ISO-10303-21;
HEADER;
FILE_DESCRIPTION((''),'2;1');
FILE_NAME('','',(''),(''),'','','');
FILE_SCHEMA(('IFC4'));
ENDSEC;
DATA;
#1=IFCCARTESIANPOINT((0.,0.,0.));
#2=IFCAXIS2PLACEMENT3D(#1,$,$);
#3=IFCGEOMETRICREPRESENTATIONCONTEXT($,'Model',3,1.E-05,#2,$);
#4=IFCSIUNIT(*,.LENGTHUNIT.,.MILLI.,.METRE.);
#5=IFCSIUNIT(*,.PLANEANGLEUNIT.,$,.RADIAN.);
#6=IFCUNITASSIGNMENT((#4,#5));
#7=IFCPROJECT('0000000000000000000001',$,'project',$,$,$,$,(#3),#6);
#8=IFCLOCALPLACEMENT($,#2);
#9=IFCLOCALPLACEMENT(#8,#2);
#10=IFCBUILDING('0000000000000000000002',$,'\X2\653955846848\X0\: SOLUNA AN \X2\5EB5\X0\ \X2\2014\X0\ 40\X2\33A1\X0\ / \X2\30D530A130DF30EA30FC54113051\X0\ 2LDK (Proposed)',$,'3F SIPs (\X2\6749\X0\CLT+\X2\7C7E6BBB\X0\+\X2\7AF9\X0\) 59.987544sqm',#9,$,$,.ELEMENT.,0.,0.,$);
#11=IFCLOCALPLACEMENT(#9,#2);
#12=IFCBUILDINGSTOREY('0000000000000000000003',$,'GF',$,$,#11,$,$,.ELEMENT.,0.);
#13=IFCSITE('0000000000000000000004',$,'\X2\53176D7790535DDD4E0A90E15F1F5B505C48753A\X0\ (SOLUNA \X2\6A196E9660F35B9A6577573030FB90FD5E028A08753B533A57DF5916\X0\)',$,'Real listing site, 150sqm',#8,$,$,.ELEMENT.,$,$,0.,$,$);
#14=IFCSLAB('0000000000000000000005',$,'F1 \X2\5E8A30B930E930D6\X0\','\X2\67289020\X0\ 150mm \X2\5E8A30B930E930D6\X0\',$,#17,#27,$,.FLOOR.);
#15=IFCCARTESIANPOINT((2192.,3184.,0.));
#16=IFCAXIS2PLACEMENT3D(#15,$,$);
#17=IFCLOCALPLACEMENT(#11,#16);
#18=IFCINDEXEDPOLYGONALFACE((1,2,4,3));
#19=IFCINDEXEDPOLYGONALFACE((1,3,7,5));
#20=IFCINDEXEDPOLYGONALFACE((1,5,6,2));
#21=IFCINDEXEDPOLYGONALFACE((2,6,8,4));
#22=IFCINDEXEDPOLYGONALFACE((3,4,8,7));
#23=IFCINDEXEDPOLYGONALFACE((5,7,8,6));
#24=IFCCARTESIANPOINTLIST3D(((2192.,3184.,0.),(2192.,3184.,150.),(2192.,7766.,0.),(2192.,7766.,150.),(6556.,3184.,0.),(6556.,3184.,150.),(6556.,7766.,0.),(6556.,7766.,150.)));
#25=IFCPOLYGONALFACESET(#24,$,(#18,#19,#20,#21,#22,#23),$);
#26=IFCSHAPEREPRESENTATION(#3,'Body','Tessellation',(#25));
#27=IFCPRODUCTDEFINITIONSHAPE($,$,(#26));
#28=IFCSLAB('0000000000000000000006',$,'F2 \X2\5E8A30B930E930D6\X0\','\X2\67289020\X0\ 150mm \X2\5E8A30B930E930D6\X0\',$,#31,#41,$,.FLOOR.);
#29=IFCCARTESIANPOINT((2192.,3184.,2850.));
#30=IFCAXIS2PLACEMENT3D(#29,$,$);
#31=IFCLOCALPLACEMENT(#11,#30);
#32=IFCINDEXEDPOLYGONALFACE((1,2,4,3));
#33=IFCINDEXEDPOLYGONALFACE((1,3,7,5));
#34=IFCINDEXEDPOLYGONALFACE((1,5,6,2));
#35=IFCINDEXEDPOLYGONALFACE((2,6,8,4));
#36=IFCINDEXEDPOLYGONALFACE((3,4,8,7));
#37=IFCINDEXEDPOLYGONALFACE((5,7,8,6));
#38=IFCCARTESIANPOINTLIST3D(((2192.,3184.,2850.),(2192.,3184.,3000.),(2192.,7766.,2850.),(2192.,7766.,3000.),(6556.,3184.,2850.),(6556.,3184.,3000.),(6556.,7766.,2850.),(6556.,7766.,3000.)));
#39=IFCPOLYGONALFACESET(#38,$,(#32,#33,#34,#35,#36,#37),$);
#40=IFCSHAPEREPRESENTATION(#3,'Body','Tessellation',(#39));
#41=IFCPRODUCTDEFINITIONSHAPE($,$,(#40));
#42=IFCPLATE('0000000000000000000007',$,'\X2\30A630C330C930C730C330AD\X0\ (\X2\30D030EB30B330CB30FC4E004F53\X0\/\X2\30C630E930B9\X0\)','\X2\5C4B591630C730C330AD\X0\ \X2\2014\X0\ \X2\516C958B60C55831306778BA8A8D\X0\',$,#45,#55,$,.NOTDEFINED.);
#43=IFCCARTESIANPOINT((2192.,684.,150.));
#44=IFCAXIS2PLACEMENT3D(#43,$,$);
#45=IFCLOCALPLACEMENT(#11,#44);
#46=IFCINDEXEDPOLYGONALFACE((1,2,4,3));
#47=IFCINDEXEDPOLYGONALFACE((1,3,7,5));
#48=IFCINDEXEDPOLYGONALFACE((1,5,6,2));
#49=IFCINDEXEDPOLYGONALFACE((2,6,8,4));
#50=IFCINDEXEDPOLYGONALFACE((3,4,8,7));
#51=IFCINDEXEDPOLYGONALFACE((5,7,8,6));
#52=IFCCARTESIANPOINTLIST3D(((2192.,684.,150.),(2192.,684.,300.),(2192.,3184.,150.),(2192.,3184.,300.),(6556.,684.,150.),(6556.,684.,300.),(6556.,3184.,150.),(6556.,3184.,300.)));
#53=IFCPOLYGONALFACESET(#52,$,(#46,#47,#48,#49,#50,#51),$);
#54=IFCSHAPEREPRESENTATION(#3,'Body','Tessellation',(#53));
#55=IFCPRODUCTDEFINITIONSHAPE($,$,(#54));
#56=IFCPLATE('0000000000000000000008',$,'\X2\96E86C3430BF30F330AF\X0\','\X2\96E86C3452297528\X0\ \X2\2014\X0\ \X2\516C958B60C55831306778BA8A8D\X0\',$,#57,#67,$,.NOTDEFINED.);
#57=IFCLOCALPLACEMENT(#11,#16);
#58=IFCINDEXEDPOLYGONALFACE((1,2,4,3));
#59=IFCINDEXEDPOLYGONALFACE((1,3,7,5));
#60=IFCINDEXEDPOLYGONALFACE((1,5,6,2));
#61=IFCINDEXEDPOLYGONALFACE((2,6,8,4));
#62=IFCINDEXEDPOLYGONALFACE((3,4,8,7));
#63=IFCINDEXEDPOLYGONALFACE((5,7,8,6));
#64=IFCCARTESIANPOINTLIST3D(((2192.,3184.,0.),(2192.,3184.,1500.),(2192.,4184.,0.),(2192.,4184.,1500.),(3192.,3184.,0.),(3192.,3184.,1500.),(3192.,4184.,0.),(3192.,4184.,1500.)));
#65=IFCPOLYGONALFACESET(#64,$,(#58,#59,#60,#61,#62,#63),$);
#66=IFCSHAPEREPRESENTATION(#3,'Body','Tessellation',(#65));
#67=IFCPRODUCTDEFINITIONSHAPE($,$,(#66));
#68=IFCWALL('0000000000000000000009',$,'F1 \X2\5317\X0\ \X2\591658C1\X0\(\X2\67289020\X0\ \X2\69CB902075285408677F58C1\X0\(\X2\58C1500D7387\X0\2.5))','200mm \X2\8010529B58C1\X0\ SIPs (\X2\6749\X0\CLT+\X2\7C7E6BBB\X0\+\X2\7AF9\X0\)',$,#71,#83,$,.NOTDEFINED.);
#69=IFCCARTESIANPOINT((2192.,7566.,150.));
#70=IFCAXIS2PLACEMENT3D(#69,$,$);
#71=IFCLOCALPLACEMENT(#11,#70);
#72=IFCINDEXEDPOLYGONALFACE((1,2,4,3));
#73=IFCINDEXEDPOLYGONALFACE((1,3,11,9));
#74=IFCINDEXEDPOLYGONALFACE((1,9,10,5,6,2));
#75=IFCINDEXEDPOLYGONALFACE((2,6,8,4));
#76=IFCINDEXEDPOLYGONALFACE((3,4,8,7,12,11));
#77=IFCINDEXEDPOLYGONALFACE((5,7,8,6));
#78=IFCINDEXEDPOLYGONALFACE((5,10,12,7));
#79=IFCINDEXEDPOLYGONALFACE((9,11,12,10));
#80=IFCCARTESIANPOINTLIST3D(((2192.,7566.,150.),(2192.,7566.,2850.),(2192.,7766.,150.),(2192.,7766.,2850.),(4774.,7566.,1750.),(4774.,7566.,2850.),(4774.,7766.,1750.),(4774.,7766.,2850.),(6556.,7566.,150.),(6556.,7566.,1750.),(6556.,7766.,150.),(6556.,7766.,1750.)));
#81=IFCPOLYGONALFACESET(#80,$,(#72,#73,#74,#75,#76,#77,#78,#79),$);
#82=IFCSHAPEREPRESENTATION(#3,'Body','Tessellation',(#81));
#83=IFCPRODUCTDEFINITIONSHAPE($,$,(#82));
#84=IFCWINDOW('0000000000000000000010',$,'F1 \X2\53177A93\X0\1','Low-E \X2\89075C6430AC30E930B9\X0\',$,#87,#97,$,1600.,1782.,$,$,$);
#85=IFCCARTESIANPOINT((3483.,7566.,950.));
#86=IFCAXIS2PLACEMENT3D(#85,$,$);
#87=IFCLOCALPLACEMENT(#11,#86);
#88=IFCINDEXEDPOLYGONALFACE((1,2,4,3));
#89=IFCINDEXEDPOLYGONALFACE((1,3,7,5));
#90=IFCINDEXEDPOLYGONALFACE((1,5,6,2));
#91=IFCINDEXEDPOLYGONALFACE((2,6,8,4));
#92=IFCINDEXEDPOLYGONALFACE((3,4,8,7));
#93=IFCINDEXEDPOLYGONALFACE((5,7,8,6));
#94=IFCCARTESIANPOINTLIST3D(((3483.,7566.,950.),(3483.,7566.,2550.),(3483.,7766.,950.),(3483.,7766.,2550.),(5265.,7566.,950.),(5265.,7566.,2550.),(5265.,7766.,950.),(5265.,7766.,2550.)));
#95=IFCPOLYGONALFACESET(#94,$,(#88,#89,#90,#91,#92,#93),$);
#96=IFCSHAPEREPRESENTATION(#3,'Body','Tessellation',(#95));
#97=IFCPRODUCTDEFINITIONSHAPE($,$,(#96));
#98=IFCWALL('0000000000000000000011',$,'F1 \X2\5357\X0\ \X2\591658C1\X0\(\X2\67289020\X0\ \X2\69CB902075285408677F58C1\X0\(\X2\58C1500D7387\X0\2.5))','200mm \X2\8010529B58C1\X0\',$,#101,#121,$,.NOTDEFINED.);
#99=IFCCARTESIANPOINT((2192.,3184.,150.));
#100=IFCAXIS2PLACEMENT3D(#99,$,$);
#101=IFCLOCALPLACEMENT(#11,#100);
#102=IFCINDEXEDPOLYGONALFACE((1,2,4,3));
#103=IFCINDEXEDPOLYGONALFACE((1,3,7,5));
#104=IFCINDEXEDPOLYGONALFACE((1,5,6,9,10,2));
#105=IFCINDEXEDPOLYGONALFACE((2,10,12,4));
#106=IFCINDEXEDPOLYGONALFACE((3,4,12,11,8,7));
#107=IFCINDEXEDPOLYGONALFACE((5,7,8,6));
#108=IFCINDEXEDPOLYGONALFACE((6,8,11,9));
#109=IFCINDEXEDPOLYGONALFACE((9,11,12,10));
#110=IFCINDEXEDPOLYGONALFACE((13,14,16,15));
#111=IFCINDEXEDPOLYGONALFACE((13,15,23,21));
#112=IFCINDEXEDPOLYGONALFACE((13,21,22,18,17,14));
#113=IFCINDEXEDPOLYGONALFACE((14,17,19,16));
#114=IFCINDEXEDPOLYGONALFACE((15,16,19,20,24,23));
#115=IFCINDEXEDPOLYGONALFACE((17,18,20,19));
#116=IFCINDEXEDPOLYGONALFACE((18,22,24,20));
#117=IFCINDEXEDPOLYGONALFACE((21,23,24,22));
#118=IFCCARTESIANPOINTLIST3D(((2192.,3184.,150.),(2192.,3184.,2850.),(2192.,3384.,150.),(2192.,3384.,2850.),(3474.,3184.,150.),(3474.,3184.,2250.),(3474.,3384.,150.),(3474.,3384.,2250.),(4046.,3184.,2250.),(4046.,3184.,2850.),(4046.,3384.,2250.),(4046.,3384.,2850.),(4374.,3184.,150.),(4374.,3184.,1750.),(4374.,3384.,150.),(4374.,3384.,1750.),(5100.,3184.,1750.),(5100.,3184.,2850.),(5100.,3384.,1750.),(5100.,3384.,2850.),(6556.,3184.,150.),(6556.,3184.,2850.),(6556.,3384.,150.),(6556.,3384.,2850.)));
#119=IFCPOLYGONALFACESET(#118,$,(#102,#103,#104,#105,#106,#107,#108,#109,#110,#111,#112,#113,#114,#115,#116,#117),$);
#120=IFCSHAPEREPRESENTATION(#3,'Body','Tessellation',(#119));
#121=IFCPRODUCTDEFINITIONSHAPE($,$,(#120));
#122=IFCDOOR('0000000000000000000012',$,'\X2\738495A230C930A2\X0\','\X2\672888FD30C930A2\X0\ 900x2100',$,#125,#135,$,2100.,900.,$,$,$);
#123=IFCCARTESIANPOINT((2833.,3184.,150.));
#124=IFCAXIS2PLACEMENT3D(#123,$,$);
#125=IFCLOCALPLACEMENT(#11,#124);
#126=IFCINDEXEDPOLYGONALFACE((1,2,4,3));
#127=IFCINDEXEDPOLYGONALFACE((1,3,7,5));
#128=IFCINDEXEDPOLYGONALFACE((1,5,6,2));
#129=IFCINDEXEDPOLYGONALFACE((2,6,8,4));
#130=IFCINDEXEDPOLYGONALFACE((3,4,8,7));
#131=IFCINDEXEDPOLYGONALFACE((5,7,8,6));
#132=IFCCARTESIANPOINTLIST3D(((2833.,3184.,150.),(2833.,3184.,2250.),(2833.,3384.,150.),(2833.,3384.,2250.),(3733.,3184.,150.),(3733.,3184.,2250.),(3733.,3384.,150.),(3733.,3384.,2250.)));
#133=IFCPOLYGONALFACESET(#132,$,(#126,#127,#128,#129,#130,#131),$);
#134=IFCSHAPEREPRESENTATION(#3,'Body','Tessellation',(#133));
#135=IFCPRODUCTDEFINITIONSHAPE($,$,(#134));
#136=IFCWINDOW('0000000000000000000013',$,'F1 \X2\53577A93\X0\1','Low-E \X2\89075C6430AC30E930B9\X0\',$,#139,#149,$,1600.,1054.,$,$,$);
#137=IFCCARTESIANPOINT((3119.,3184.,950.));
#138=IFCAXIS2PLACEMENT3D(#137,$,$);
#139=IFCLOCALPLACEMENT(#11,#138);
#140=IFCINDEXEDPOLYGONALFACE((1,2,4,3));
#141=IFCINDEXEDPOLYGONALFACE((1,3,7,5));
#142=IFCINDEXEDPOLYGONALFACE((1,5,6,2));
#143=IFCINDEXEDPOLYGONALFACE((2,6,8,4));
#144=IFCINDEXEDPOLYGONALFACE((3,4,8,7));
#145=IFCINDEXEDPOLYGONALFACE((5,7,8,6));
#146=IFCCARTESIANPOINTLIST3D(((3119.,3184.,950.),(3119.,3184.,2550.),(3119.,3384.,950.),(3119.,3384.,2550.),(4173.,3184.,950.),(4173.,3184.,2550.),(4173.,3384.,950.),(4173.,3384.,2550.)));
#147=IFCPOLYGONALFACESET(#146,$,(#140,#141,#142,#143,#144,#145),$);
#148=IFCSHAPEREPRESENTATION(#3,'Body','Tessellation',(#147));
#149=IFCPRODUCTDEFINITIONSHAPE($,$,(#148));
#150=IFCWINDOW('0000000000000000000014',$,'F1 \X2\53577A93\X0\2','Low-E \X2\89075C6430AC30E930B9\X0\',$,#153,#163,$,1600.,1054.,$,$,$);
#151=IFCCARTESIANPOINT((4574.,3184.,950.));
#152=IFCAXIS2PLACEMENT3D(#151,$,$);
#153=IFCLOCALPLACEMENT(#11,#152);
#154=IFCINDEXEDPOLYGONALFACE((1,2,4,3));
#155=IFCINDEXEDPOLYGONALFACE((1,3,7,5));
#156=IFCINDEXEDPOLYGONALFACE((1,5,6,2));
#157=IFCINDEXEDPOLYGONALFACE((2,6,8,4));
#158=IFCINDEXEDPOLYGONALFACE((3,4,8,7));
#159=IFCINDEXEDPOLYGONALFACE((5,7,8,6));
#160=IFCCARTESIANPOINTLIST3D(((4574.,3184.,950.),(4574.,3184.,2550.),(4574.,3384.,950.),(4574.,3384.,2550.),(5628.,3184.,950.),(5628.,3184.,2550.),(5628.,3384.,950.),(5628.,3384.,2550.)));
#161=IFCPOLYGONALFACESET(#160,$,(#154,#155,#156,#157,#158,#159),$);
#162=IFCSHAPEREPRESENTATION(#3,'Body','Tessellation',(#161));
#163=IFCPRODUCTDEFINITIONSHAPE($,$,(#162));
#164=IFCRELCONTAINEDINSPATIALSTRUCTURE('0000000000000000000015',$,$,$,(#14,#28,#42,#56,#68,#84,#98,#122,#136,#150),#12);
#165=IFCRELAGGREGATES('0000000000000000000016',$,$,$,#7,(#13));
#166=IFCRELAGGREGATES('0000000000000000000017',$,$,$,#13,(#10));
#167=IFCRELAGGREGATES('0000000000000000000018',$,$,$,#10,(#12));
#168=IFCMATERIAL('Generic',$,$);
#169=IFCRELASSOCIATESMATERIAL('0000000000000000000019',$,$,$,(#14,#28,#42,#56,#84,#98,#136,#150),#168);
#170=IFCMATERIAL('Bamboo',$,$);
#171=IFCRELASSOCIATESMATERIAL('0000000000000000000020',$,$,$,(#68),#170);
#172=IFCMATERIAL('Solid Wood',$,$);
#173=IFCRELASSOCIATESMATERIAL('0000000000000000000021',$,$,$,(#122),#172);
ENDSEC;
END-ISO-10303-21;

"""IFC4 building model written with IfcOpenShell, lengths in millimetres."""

from ifc_helpers import new_model, si_unit, frame, frame_2d, origin, place, context, project, spatial, rectangle, extrude, material, element, fill, save


model = new_model("IFC4")

# Units and contexts
model_context = context("Model", 3, precision=1e-05, world=origin())
ifc_project = project(units=[si_unit("LENGTHUNIT", "METRE", prefix="MILLI"), si_unit("PLANEANGLEUNIT", "RADIAN")], contexts=[model_context])

# Site, building, storey
site_placement = place(None, origin())
site = spatial("IfcSite", under=ifc_project, at=site_placement, Name="北海道川上郡弟子屈町 (SOLUNA 標準想定敷地・都市計画区域外)", ObjectType="Real listing site, 150sqm", CompositionType="ELEMENT", RefElevation=0.0)
building_placement = place(site_placement, origin())
building = spatial("IfcBuilding", under=site, at=building_placement, Name="改善案: SOLUNA AN 庵 — 40㎡ / ファミリー向け 2LDK (Proposed)", ObjectType="3F SIPs (杉CLT+籾殻+竹) 59.987544sqm", CompositionType="ELEMENT", ElevationOfRefHeight=0.0, ElevationOfTerrain=0.0)
storey_placement = place(building_placement, origin())
storey = spatial("IfcBuildingStorey", under=building, at=storey_placement, Name="GF", CompositionType="ELEMENT", Elevation=0.0)

# Slabs
ifc_material_1 = material(Name="Generic")
slab_1_placement = place(storey_placement, frame((2192.0, 3184.0, 0.0)))
element("IfcSlab", 1, at=slab_1_placement, inside=storey, material=ifc_material_1, Name="F1 床スラブ", Description="木造 150mm 床スラブ", PredefinedType="FLOOR", context=model_context, shape_type="SweptSolid", body=[
    extrude(rectangle(XDim=4364.0, YDim=4582.0, at=frame_2d((2182.0, 2291.0))), frame((2192.0, 3184.0, 0.0)), (0.0, 0.0, 1.0), 150.0),
])
slab_2_placement = place(storey_placement, frame((2192.0, 3184.0, 2850.0)))
element("IfcSlab", 2, at=slab_2_placement, inside=storey, material=ifc_material_1, Name="F2 床スラブ", Description="木造 150mm 床スラブ", PredefinedType="FLOOR", context=model_context, shape_type="SweptSolid", body=[
    extrude(rectangle(XDim=4364.0, YDim=4582.0, at=frame_2d((2182.0, 2291.0))), frame((2192.0, 3184.0, 2850.0)), (0.0, 0.0, 1.0), 150.0),
])

# Plates
plate_1_placement = place(storey_placement, frame((2192.0, 684.0, 150.0)))
element("IfcPlate", 3, at=plate_1_placement, inside=storey, material=ifc_material_1, Name="ウッドデッキ (バルコニー一体/テラス)", Description="屋外デッキ — 公開情報で確認", PredefinedType="NOTDEFINED", context=model_context, shape_type="SweptSolid", body=[
    extrude(rectangle(XDim=4364.0, YDim=2500.0, at=frame_2d((2182.0, 1250.0))), frame((2192.0, 684.0, 150.0)), (0.0, 0.0, 1.0), 150.0),
])
plate_2_placement = place(storey_placement, frame((2192.0, 3184.0, 0.0)))
element("IfcPlate", 4, at=plate_2_placement, inside=storey, material=ifc_material_1, Name="雨水タンク", Description="雨水利用 — 公開情報で確認", PredefinedType="NOTDEFINED", context=model_context, shape_type="SweptSolid", body=[
    extrude(rectangle(XDim=1000.0, YDim=1000.0, at=frame_2d((500.0, 500.0))), frame((2192.0, 3184.0, 0.0)), (0.0, 0.0, 1.0), 1500.0),
])

# Wall, opening, window
ifc_material_2 = material(Name="Bamboo")
wall_1_placement = place(storey_placement, frame((2192.0, 7566.0, 150.0)))
wall_1 = element("IfcWall", 5, at=wall_1_placement, inside=storey, material=ifc_material_2, Name="F1 北 外壁(木造 構造用合板壁(壁倍率2.5))", Description="200mm 耐力壁 SIPs (杉CLT+籾殻+竹)", PredefinedType="NOTDEFINED", context=model_context, shape_type="SweptSolid", body=[
    extrude(rectangle(XDim=4364.0, YDim=200.0, at=frame_2d((2182.0, 100.0))), frame((2192.0, 7566.0, 150.0)), (0.0, 0.0, 1.0), 2700.0),
])
opening_1_placement = place(storey_placement, frame((3483.0, 7566.0, 950.0)))
opening_1 = element("IfcOpeningElement", 6, at=opening_1_placement, cuts=wall_1, PredefinedType="NOTDEFINED", context=model_context, shape_type="SweptSolid", body=[
    extrude(rectangle(XDim=1782.0, YDim=200.0, at=frame_2d((891.0, 100.0))), frame((3483.0, 7566.0, 950.0)), (0.0, 0.0, 1.0), 1600.0),
])
window_1_placement = place(storey_placement, frame((3483.0, 7566.0, 950.0)))
window_1 = element("IfcWindow", 7, at=window_1_placement, inside=storey, material=ifc_material_1, Name="F1 北窓1", Description="Low-E 複層ガラス", OverallHeight=1600.0, OverallWidth=1782.0, context=model_context, shape_type="SweptSolid", body=[
    extrude(rectangle(XDim=1782.0, YDim=200.0, at=frame_2d((891.0, 100.0))), frame((3483.0, 7566.0, 950.0)), (0.0, 0.0, 1.0), 1600.0),
])
fill(opening_1, window_1)

# Wall, openings, door, windows
wall_2_placement = place(storey_placement, frame((2192.0, 3184.0, 150.0)))
wall_2 = element("IfcWall", 8, at=wall_2_placement, inside=storey, material=ifc_material_1, Name="F1 南 外壁(木造 構造用合板壁(壁倍率2.5))", Description="200mm 耐力壁", PredefinedType="NOTDEFINED", context=model_context, shape_type="SweptSolid", body=[
    extrude(rectangle(XDim=4364.0, YDim=200.0, at=frame_2d((2182.0, 100.0))), frame((2192.0, 3184.0, 150.0)), (0.0, 0.0, 1.0), 2700.0),
])
opening_2_placement = place(storey_placement, frame((2833.0, 3184.0, 150.0)))
opening_2 = element("IfcOpeningElement", 9, at=opening_2_placement, cuts=wall_2, PredefinedType="NOTDEFINED", context=model_context, shape_type="SweptSolid", body=[
    extrude(rectangle(XDim=900.0, YDim=200.0, at=frame_2d((450.0, 100.0))), frame((2833.0, 3184.0, 150.0)), (0.0, 0.0, 1.0), 2100.0),
])
opening_3_placement = place(storey_placement, frame((3119.0, 3184.0, 950.0)))
opening_3 = element("IfcOpeningElement", 10, at=opening_3_placement, cuts=wall_2, PredefinedType="NOTDEFINED", context=model_context, shape_type="SweptSolid", body=[
    extrude(rectangle(XDim=1054.0, YDim=200.0, at=frame_2d((527.0, 100.0))), frame((3119.0, 3184.0, 950.0)), (0.0, 0.0, 1.0), 1600.0),
])
opening_4_placement = place(storey_placement, frame((4574.0, 3184.0, 950.0)))
opening_4 = element("IfcOpeningElement", 11, at=opening_4_placement, cuts=wall_2, PredefinedType="NOTDEFINED", context=model_context, shape_type="SweptSolid", body=[
    extrude(rectangle(XDim=1054.0, YDim=200.0, at=frame_2d((527.0, 100.0))), frame((4574.0, 3184.0, 950.0)), (0.0, 0.0, 1.0), 1600.0),
])
ifc_material_3 = material(Name="Solid Wood")
door_placement = place(storey_placement, frame((2833.0, 3184.0, 150.0)))
door = element("IfcDoor", 12, at=door_placement, inside=storey, material=ifc_material_3, Name="玄関ドア", Description="木製ドア 900x2100", OverallHeight=2100.0, OverallWidth=900.0, context=model_context, shape_type="SweptSolid", body=[
    extrude(rectangle(XDim=900.0, YDim=200.0, at=frame_2d((450.0, 100.0))), frame((2833.0, 3184.0, 150.0)), (0.0, 0.0, 1.0), 2100.0),
])
fill(opening_2, door)
window_2_placement = place(storey_placement, frame((3119.0, 3184.0, 950.0)))
window_2 = element("IfcWindow", 13, at=window_2_placement, inside=storey, material=ifc_material_1, Name="F1 南窓1", Description="Low-E 複層ガラス", OverallHeight=1600.0, OverallWidth=1054.0, context=model_context, shape_type="SweptSolid", body=[
    extrude(rectangle(XDim=1054.0, YDim=200.0, at=frame_2d((527.0, 100.0))), frame((3119.0, 3184.0, 950.0)), (0.0, 0.0, 1.0), 1600.0),
])
fill(opening_3, window_2)
window_3_placement = place(storey_placement, frame((4574.0, 3184.0, 950.0)))
window_3 = element("IfcWindow", 14, at=window_3_placement, inside=storey, material=ifc_material_1, Name="F1 南窓2", Description="Low-E 複層ガラス", OverallHeight=1600.0, OverallWidth=1054.0, context=model_context, shape_type="SweptSolid", body=[
    extrude(rectangle(XDim=1054.0, YDim=200.0, at=frame_2d((527.0, 100.0))), frame((4574.0, 3184.0, 950.0)), (0.0, 0.0, 1.0), 1600.0),
])
fill(opening_4, window_3)

save(model, "model.ifc")
